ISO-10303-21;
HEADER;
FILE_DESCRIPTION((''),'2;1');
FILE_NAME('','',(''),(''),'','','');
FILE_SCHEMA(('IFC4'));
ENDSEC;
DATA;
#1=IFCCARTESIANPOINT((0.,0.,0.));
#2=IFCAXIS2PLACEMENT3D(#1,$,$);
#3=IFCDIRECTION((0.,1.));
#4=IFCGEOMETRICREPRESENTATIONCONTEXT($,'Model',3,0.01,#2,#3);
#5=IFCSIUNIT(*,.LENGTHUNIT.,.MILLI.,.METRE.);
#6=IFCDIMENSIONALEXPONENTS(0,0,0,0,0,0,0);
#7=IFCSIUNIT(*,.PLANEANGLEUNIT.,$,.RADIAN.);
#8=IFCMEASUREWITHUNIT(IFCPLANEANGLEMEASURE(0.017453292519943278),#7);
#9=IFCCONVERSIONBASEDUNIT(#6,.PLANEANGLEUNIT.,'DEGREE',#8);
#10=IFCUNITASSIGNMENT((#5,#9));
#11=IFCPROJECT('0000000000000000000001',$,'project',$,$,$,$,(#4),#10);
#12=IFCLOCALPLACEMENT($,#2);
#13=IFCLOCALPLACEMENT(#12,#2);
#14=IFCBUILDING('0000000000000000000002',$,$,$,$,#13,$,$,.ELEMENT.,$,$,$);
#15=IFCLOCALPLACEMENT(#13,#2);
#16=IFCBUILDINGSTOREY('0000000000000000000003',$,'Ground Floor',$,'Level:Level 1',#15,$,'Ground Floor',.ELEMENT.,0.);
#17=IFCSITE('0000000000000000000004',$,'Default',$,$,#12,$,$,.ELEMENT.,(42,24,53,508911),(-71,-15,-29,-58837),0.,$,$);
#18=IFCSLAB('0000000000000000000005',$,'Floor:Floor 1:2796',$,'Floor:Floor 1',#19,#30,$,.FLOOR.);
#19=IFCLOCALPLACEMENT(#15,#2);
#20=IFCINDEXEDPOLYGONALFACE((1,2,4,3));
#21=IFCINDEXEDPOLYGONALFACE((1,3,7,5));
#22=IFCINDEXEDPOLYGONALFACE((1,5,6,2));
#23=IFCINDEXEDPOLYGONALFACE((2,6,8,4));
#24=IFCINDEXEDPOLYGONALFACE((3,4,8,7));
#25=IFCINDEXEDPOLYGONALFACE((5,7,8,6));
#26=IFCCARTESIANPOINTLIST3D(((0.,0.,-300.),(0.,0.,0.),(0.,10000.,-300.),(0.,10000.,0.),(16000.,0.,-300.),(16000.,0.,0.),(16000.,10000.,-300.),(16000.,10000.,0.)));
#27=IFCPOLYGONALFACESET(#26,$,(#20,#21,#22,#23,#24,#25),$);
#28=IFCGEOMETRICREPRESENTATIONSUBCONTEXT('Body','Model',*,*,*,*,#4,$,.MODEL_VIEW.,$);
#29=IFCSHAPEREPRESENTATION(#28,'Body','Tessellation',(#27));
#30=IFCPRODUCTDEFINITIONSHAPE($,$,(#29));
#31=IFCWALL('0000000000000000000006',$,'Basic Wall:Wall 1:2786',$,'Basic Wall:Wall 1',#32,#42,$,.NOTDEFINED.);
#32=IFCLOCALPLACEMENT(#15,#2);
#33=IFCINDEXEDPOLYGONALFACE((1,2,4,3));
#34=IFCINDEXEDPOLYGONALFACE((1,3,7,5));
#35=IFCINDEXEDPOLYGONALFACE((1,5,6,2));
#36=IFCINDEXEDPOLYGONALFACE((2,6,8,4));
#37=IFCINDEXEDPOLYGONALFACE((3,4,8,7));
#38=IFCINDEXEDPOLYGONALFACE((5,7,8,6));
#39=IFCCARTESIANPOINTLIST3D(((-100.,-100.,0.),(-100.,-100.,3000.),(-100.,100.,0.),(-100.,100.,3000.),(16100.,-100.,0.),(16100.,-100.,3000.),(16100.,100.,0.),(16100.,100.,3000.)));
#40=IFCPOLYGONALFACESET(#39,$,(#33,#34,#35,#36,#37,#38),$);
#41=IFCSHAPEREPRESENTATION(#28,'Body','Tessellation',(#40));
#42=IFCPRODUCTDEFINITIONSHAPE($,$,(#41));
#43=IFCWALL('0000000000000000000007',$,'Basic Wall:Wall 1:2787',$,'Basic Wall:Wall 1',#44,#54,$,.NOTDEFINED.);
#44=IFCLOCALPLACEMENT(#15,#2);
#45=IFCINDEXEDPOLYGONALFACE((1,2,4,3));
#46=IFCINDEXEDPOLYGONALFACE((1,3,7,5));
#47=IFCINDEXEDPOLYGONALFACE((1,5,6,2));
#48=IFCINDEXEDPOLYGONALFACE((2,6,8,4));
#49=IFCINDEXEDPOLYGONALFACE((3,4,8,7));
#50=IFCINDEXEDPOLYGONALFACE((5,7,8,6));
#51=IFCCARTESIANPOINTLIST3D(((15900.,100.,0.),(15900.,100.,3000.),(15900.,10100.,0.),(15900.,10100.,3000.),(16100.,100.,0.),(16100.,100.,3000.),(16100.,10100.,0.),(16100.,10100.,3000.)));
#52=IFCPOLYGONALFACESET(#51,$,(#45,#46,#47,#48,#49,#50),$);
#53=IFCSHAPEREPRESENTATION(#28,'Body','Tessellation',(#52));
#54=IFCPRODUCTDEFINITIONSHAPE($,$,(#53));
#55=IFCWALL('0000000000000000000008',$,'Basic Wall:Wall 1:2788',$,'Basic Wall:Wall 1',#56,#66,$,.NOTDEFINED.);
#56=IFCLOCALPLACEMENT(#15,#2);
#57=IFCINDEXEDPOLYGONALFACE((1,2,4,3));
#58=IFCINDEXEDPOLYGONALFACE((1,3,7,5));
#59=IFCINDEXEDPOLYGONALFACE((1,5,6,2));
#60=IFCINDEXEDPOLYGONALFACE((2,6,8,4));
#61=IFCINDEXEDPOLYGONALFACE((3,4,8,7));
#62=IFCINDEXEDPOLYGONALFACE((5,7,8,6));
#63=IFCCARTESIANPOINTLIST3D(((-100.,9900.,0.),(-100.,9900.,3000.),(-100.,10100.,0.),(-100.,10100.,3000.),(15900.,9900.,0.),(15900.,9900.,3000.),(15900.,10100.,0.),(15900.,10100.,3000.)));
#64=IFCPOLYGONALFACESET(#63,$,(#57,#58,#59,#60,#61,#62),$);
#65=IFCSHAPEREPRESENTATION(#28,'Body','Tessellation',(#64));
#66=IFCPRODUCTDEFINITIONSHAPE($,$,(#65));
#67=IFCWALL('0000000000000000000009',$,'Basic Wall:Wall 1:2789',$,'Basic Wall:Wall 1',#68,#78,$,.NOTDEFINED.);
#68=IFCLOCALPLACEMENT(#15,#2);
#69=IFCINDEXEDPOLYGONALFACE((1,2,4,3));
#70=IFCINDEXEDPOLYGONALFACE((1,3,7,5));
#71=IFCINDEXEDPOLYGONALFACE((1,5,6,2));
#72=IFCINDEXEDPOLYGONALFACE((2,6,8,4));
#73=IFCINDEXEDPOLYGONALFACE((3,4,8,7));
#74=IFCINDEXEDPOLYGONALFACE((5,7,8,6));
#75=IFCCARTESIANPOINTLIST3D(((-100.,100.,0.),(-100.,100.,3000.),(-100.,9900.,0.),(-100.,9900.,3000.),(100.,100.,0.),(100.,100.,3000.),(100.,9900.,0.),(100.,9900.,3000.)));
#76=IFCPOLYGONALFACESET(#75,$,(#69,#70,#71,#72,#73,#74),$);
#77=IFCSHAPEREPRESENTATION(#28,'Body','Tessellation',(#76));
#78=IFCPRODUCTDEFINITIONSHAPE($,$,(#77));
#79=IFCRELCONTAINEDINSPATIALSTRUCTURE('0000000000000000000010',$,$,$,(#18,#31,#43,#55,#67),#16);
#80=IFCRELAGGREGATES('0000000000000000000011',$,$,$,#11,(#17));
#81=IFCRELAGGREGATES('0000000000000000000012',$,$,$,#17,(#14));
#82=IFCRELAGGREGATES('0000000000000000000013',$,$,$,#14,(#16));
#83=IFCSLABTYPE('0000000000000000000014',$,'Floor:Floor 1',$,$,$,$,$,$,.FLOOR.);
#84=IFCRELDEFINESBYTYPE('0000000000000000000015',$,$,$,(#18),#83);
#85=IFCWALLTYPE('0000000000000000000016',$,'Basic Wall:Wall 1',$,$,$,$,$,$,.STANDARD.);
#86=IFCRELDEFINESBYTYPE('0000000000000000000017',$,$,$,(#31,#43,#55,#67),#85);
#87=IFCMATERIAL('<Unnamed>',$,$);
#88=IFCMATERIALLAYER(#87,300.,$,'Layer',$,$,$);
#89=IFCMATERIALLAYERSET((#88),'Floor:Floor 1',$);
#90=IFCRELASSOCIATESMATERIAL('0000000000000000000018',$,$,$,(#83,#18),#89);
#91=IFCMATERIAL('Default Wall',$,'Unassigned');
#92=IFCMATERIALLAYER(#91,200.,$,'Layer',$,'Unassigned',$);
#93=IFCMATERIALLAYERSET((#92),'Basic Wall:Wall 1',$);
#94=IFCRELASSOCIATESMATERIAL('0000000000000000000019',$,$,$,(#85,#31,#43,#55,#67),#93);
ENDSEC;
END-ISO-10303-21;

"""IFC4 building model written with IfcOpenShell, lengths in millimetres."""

from ifc_helpers import new_model, entity, si_unit, converted_unit, direction, frame, frame_2d, origin, origin_2d_with_axis, place, context, subcontext, project, spatial, rectangle, extrude, material, layer, layer_set, layer_usage, type_object, element, save


model = new_model("IFC4")

# Units and contexts
model_context = context("Model", 3, precision=0.01, world=origin(), true_north=direction((0.0, 1.0)))
body_context = subcontext(model_context, "Body", "Model", "MODEL_VIEW")
ifc_project = project(units=[si_unit("LENGTHUNIT", "METRE", prefix="MILLI"), converted_unit("PLANEANGLEUNIT", "DEGREE", entity("IfcPlaneAngleMeasure", 0.017453292519943278), si_unit("PLANEANGLEUNIT", "RADIAN"), dimensions=[0, 0, 0, 0, 0, 0, 0])], contexts=[model_context])

# Site, building, storey
site_placement = place(None, origin())
site = spatial("IfcSite", under=ifc_project, at=site_placement, Name="Default", CompositionType="ELEMENT", RefLatitude=(42, 24, 53, 508911), RefLongitude=(-71, -15, -29, -58837), RefElevation=0.0)
building_placement = place(site_placement, origin())
building = spatial("IfcBuilding", under=site, at=building_placement, CompositionType="ELEMENT")
storey_placement = place(building_placement, origin())
storey = spatial("IfcBuildingStorey", under=building, at=storey_placement, Name="Ground Floor", ObjectType="Level:Level 1", LongName="Ground Floor", CompositionType="ELEMENT", Elevation=0.0)

# Shared definitions
ifc_material_1 = material(Name="Default Wall", Category="Unassigned")

# Slab
ifc_material_2 = material(Name="<Unnamed>")
ifc_layer_1 = layer(ifc_material_2, 300.0, Name="Layer")
ifc_layer_set_1 = layer_set([ifc_layer_1], Name="Floor:Floor 1")
ifc_layer_usage_1 = layer_usage(ifc_layer_set_1, "AXIS3", "POSITIVE", 0.0)
slab_type = type_object("IfcSlabType", Name="Floor:Floor 1", PredefinedType="FLOOR", material=ifc_layer_set_1)
slab_placement = place(storey_placement, origin())
element("IfcSlab", 1, at=slab_placement, inside=storey, type_object=slab_type, material=ifc_layer_usage_1, Name="Floor:Floor 1:2796", ObjectType="Floor:Floor 1", PredefinedType="FLOOR", context=body_context, shape_type="SweptSolid", body=[
    extrude(rectangle(XDim=10000.0, YDim=16000.0, at=origin_2d_with_axis()), frame((8000.0, 5000.0, 0.0), z_axis=(0.0, 0.0, -1.0), x_axis=(0.0, 1.0, 0.0)), (0.0, 0.0, 1.0), 300.0),
])

# Walls
ifc_layer_2 = layer(ifc_material_1, 200.0, Name="Layer", Category="Unassigned")
ifc_layer_set_2 = layer_set([ifc_layer_2], Name="Basic Wall:Wall 1")
ifc_layer_usage_2 = layer_usage(ifc_layer_set_2, "AXIS2", "NEGATIVE", 100.0)
wall_type = type_object("IfcWallType", Name="Basic Wall:Wall 1", PredefinedType="STANDARD", material=ifc_layer_set_2)
wall_1_placement = place(storey_placement, frame((-100.0, 0.0, 0.0)))
element("IfcWall", 2, at=wall_1_placement, inside=storey, type_object=wall_type, material=ifc_layer_usage_2, Name="Basic Wall:Wall 1:2786", ObjectType="Basic Wall:Wall 1", PredefinedType="NOTDEFINED", context=body_context, shape_type="SweptSolid", body=[
    extrude(rectangle(XDim=16200.0, YDim=200.0, at=frame_2d((8100.0, 0.0), x_axis=(-1.0, 0.0))), origin(), (0.0, 0.0, 1.0), 3000.0),
])
ifc_layer_usage_3 = layer_usage(ifc_layer_set_2, "AXIS2", "NEGATIVE", 100.0)
wall_2_placement = place(storey_placement, frame((16000.0, 100.0, 0.0), z_axis=(0.0, 0.0, 1.0), x_axis=(0.0, 1.0, 0.0)))
element("IfcWall", 3, at=wall_2_placement, inside=storey, type_object=wall_type, material=ifc_layer_usage_3, Name="Basic Wall:Wall 1:2787", ObjectType="Basic Wall:Wall 1", PredefinedType="NOTDEFINED", context=body_context, shape_type="SweptSolid", body=[
    extrude(rectangle(XDim=10000.0, YDim=200.0, at=frame_2d((5000.0, 0.0), x_axis=(-1.0, 0.0))), origin(), (0.0, 0.0, 1.0), 3000.0),
])
ifc_layer_usage_4 = layer_usage(ifc_layer_set_2, "AXIS2", "NEGATIVE", 100.0)
wall_3_placement = place(storey_placement, frame((15900.0, 10000.0, 0.0), z_axis=(0.0, 0.0, 1.0), x_axis=(-1.0, 0.0, 0.0)))
element("IfcWall", 4, at=wall_3_placement, inside=storey, type_object=wall_type, material=ifc_layer_usage_4, Name="Basic Wall:Wall 1:2788", ObjectType="Basic Wall:Wall 1", PredefinedType="NOTDEFINED", context=body_context, shape_type="SweptSolid", body=[
    extrude(rectangle(XDim=16000.0, YDim=200.0, at=frame_2d((8000.0, 0.0), x_axis=(-1.0, 0.0))), origin(), (0.0, 0.0, 1.0), 3000.0),
])
ifc_layer_usage_5 = layer_usage(ifc_layer_set_2, "AXIS2", "NEGATIVE", 100.0)
wall_4_placement = place(storey_placement, frame((0.0, 9900.0, 0.0), z_axis=(0.0, 0.0, 1.0), x_axis=(0.0, -1.0, 0.0)))
element("IfcWall", 5, at=wall_4_placement, inside=storey, type_object=wall_type, material=ifc_layer_usage_5, Name="Basic Wall:Wall 1:2789", ObjectType="Basic Wall:Wall 1", PredefinedType="NOTDEFINED", context=body_context, shape_type="SweptSolid", body=[
    extrude(rectangle(XDim=9800.0, YDim=200.0, at=frame_2d((4900.0, 0.0), x_axis=(-1.0, 0.0))), origin(), (0.0, 0.0, 1.0), 3000.0),
])

save(model, "model.ifc")
